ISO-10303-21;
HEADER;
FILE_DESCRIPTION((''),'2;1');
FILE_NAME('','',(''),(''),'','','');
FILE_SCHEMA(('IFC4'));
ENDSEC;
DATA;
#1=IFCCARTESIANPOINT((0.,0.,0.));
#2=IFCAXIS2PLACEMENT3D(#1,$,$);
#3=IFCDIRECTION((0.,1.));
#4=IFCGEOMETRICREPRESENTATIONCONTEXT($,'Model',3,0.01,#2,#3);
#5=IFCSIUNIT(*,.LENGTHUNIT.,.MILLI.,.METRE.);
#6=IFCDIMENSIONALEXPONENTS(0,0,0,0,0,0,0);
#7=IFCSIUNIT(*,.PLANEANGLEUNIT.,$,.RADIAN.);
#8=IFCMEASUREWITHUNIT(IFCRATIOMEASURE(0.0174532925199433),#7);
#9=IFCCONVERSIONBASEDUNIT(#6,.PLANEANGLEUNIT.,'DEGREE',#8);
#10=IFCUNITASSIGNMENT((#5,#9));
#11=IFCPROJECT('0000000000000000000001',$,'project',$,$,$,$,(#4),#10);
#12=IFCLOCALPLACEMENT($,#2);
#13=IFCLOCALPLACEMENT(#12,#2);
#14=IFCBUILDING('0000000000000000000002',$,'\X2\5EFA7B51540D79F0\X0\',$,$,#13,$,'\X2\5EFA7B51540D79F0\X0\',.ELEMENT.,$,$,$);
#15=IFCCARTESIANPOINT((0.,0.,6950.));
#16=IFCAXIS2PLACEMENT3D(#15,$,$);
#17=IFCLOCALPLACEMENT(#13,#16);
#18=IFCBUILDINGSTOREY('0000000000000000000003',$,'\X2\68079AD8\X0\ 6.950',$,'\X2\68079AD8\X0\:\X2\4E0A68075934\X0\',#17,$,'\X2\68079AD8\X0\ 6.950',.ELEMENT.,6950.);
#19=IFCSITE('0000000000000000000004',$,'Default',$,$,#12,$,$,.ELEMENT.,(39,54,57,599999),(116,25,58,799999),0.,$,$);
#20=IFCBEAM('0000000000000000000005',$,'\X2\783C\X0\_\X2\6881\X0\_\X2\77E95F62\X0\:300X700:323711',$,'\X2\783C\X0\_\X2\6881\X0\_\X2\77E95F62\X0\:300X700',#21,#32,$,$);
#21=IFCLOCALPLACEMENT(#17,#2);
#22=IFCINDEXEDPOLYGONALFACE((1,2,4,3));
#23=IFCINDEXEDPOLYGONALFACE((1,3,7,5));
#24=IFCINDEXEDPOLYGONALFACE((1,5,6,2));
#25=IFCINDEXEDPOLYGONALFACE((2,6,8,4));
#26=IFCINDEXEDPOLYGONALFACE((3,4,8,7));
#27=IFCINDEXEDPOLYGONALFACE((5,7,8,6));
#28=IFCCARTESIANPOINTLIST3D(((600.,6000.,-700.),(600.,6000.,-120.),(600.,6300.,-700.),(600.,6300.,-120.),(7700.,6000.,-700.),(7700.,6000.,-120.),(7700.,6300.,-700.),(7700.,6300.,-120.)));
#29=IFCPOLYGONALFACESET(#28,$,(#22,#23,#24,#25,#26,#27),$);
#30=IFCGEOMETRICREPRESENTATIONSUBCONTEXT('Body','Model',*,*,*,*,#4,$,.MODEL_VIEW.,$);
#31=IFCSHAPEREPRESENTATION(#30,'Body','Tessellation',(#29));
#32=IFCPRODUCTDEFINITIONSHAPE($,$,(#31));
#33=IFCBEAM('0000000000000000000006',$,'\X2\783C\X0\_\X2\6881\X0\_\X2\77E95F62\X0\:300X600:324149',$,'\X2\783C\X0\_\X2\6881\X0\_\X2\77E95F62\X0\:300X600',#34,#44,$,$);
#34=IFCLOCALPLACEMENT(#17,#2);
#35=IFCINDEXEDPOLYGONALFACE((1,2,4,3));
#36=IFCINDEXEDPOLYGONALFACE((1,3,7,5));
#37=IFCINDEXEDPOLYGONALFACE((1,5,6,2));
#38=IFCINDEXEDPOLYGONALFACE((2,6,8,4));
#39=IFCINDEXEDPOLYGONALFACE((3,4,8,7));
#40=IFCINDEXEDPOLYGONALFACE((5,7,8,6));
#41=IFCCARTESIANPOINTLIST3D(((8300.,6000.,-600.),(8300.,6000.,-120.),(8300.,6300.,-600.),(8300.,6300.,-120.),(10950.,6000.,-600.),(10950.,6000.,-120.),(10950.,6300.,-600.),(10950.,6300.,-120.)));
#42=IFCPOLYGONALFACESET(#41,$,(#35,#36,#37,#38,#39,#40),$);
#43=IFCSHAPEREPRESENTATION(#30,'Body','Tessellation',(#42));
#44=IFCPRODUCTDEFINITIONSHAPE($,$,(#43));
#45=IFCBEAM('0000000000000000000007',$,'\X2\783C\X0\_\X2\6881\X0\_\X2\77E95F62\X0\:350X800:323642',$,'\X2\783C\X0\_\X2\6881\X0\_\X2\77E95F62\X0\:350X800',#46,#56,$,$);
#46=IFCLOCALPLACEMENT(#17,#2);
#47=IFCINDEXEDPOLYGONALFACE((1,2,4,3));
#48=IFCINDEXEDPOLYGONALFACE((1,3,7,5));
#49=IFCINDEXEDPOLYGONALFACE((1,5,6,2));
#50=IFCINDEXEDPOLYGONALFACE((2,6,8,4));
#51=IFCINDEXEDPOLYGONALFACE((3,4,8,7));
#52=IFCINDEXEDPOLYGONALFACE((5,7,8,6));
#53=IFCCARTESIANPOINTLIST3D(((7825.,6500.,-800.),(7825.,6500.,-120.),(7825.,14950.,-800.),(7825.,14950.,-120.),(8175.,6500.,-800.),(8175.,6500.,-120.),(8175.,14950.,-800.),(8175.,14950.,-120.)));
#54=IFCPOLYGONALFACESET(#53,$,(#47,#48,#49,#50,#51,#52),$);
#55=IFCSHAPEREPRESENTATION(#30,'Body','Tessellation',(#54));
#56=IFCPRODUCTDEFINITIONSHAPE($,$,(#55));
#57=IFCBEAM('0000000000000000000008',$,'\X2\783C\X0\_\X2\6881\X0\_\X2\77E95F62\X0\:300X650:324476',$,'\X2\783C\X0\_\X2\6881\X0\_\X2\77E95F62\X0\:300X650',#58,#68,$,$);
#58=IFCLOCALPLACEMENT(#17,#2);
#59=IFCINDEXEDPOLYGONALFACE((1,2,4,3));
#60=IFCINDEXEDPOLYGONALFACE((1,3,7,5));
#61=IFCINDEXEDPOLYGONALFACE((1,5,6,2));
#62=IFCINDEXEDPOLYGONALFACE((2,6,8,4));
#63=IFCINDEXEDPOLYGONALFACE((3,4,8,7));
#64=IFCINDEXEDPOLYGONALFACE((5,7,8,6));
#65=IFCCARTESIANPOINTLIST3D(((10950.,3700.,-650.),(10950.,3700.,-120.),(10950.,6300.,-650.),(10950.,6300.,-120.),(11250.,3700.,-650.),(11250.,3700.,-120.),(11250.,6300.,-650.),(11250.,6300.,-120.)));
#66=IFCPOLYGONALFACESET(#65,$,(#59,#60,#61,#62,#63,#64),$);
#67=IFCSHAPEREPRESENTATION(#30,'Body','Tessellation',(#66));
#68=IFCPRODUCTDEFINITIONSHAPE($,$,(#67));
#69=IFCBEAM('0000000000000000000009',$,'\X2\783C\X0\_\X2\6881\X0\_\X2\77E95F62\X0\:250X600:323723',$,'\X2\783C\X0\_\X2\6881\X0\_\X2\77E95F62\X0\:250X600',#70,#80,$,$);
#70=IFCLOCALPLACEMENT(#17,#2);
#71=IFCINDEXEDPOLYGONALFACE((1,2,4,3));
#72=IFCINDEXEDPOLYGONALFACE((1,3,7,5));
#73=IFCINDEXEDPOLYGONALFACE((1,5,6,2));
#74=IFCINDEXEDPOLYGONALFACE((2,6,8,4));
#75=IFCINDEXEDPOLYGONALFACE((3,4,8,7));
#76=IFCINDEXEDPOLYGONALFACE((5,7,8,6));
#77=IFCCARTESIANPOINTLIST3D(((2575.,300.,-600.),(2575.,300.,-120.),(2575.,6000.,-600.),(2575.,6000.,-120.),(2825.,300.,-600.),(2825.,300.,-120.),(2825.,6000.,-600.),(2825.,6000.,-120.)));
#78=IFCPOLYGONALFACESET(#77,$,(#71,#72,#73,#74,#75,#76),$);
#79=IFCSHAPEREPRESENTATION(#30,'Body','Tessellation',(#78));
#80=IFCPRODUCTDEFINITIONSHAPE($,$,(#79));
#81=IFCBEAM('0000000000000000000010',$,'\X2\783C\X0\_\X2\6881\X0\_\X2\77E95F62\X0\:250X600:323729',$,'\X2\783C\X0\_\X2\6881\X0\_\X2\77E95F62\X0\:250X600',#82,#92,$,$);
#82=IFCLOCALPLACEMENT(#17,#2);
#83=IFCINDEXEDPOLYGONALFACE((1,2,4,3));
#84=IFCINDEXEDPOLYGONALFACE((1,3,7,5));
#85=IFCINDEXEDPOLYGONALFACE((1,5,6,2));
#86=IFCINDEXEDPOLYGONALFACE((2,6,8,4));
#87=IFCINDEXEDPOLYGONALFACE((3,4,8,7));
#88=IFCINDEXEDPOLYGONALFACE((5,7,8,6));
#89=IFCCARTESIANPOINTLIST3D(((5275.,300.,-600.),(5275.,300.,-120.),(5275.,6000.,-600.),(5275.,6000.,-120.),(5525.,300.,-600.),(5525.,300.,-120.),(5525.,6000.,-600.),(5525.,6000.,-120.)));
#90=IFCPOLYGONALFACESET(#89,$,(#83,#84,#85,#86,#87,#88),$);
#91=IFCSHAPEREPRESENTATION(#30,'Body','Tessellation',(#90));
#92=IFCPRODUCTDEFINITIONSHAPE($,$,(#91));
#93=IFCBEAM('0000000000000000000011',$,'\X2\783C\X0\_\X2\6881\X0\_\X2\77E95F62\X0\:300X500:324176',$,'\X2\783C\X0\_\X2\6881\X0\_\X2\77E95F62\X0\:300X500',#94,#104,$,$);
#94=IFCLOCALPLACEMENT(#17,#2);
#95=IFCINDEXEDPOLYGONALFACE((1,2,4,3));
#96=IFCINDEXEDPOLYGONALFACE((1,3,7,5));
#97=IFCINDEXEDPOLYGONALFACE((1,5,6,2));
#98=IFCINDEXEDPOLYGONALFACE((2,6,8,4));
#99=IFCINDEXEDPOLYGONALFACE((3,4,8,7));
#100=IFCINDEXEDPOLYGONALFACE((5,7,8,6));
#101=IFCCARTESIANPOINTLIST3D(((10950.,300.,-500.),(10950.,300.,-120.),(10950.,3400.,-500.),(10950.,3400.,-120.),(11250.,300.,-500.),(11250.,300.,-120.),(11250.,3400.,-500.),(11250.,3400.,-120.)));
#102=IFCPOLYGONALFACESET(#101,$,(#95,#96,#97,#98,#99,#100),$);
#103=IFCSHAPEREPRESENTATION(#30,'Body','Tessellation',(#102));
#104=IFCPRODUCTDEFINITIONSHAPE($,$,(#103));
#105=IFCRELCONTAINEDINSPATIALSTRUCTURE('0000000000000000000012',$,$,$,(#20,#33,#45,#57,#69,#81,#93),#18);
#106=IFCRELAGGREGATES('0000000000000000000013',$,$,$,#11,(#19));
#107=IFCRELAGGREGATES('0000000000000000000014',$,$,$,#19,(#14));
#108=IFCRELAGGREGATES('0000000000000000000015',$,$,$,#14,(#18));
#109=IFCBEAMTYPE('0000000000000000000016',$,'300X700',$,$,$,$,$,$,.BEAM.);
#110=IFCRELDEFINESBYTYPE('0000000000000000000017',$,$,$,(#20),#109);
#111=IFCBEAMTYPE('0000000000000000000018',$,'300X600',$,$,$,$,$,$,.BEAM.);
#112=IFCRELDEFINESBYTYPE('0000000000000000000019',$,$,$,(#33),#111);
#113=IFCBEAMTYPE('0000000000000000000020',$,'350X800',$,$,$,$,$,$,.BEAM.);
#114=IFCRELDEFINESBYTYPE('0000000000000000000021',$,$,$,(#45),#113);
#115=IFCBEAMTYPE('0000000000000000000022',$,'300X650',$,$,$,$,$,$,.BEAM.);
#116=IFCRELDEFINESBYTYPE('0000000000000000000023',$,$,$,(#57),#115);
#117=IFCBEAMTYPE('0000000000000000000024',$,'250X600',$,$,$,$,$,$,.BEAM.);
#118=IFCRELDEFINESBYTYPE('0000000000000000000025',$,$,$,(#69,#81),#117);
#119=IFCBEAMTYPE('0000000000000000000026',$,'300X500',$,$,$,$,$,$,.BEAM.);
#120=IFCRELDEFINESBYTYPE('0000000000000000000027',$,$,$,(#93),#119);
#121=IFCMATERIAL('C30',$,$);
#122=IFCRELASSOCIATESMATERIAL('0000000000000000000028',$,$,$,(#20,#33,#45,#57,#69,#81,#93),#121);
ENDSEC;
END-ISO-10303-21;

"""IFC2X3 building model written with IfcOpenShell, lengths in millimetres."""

from ifc_helpers import new_model, entity, si_unit, converted_unit, direction, frame, frame_2d, origin, origin_2d_with_axis, place, context, subcontext, project, spatial, rectangle, extrude, material, type_object, element, save


model = new_model("IFC2X3")

# Units and contexts
model_context = context("Model", 3, precision=0.01, world=origin(), true_north=direction((0.0, 1.0)))
body_context = subcontext(model_context, "Body", "Model", "MODEL_VIEW")
ifc_project = project(units=[si_unit("LENGTHUNIT", "METRE", prefix="MILLI"), converted_unit("PLANEANGLEUNIT", "DEGREE", entity("IfcRatioMeasure", 0.0174532925199433), si_unit("PLANEANGLEUNIT", "RADIAN"), dimensions=[0, 0, 0, 0, 0, 0, 0])], contexts=[model_context])

# Site, building, storey
site_placement = place(None, origin())
site = spatial("IfcSite", under=ifc_project, at=site_placement, Name="Default", CompositionType="ELEMENT", RefLatitude=(39, 54, 57, 599999), RefLongitude=(116, 25, 58, 799999), RefElevation=0.0)
building_placement = place(site_placement, origin())
building = spatial("IfcBuilding", under=site, at=building_placement, Name="建筑名称", LongName="建筑名称", CompositionType="ELEMENT")
storey_placement = place(building_placement, frame((0.0, 0.0, 6950.0)))
storey = spatial("IfcBuildingStorey", under=building, at=storey_placement, Name="标高 6.950", ObjectType="标高:上标头", LongName="标高 6.950", CompositionType="ELEMENT", Elevation=6950.0)

# Shared definitions
ifc_material = material(Name="C30")

# Beams
beam_type_1 = type_object("IfcBeamType", Name="300X700", PredefinedType="BEAM")
beam_1_placement = place(storey_placement, frame((150.0, 6150.0, 0.0)))
element("IfcBeam", 1, at=beam_1_placement, inside=storey, type_object=beam_type_1, material=ifc_material, Name="砼_梁_矩形:300X700:323711", ObjectType="砼_梁_矩形:300X700", context=body_context, shape_type="SweptSolid", body=[
    extrude(rectangle(XDim=580.0, YDim=300.0, at=origin_2d_with_axis()), frame((450.0, 0.0, -410.0), z_axis=(1.0, 0.0, 0.0), x_axis=(0.0, 0.0, -1.0)), (0.0, 0.0, 1.0), 7100.0),
])
beam_type_2 = type_object("IfcBeamType", Name="300X600", PredefinedType="BEAM")
beam_2_placement = place(storey_placement, frame((8000.0, 6150.0, 0.0)))
element("IfcBeam", 2, at=beam_2_placement, inside=storey, type_object=beam_type_2, material=ifc_material, Name="砼_梁_矩形:300X600:324149", ObjectType="砼_梁_矩形:300X600", context=body_context, shape_type="SweptSolid", body=[
    extrude(rectangle(XDim=480.0, YDim=300.0, at=frame_2d((0.0, 0.0), x_axis=(1.0, 0.0))), frame((300.0, 0.0, -360.0), z_axis=(1.0, 0.0, 0.0), x_axis=(0.0, 0.0, -1.0)), (0.0, 0.0, 1.0), 2650.0),
])
beam_type_3 = type_object("IfcBeamType", Name="350X800", PredefinedType="BEAM")
beam_3_placement = place(storey_placement, frame((8000.0, 6150.0, 0.0), z_axis=(0.0, 0.0, 1.0), x_axis=(0.0, 1.0, 0.0)))
element("IfcBeam", 3, at=beam_3_placement, inside=storey, type_object=beam_type_3, material=ifc_material, Name="砼_梁_矩形:350X800:323642", ObjectType="砼_梁_矩形:350X800", context=body_context, shape_type="SweptSolid", body=[
    extrude(rectangle(XDim=680.0, YDim=350.0, at=frame_2d((0.0, 0.0), x_axis=(1.0, 0.0))), frame((350.0, 0.0, -460.0), z_axis=(1.0, 0.0, 0.0), x_axis=(0.0, 0.0, -1.0)), (0.0, 0.0, 1.0), 8450.0),
])
beam_type_4 = type_object("IfcBeamType", Name="300X650", PredefinedType="BEAM")
beam_4_placement = place(storey_placement, frame((11100.0, 3700.0, 0.0), z_axis=(0.0, 0.0, 1.0), x_axis=(0.0, 1.0, 0.0)))
element("IfcBeam", 4, at=beam_4_placement, inside=storey, type_object=beam_type_4, material=ifc_material, Name="砼_梁_矩形:300X650:324476", ObjectType="砼_梁_矩形:300X650", context=body_context, shape_type="SweptSolid", body=[
    extrude(rectangle(XDim=530.0, YDim=300.0, at=frame_2d((0.0, 0.0), x_axis=(1.0, 0.0))), frame((0.0, 0.0, -385.0), z_axis=(1.0, 0.0, 0.0), x_axis=(0.0, 0.0, -1.0)), (0.0, 0.0, 1.0), 2600.0),
])
beam_type_5 = type_object("IfcBeamType", Name="250X600", PredefinedType="BEAM")
beam_5_placement = place(storey_placement, frame((2700.0, 0.0, 0.0), z_axis=(0.0, 0.0, 1.0), x_axis=(0.0, 1.0, 0.0)))
element("IfcBeam", 5, at=beam_5_placement, inside=storey, type_object=beam_type_5, material=ifc_material, Name="砼_梁_矩形:250X600:323723", ObjectType="砼_梁_矩形:250X600", context=body_context, shape_type="SweptSolid", body=[
    extrude(rectangle(XDim=480.0, YDim=250.0, at=frame_2d((0.0, 0.0), x_axis=(1.0, 0.0))), frame((300.0, 0.0, -360.0), z_axis=(1.0, 0.0, 0.0), x_axis=(0.0, 0.0, -1.0)), (0.0, 0.0, 1.0), 5700.0),
])
beam_6_placement = place(storey_placement, frame((5400.0, 0.0, 0.0), z_axis=(0.0, 0.0, 1.0), x_axis=(0.0, 1.0, 0.0)))
element("IfcBeam", 6, at=beam_6_placement, inside=storey, type_object=beam_type_5, material=ifc_material, Name="砼_梁_矩形:250X600:323729", ObjectType="砼_梁_矩形:250X600", context=body_context, shape_type="SweptSolid", body=[
    extrude(rectangle(XDim=480.0, YDim=250.0, at=frame_2d((0.0, 0.0), x_axis=(1.0, 0.0))), frame((300.0, 0.0, -360.0), z_axis=(1.0, 0.0, 0.0), x_axis=(0.0, 0.0, -1.0)), (0.0, 0.0, 1.0), 5700.0),
])
beam_type_6 = type_object("IfcBeamType", Name="300X500", PredefinedType="BEAM")
beam_7_placement = place(storey_placement, frame((11100.0, 0.0, 0.0), z_axis=(0.0, 0.0, 1.0), x_axis=(0.0, 1.0, 0.0)))
element("IfcBeam", 7, at=beam_7_placement, inside=storey, type_object=beam_type_6, material=ifc_material, Name="砼_梁_矩形:300X500:324176", ObjectType="砼_梁_矩形:300X500", context=body_context, shape_type="SweptSolid", body=[
    extrude(rectangle(XDim=380.0, YDim=300.0, at=frame_2d((0.0, 0.0), x_axis=(1.0, 0.0))), frame((300.0, 0.0, -310.0), z_axis=(1.0, 0.0, 0.0), x_axis=(0.0, 0.0, -1.0)), (0.0, 0.0, 1.0), 3100.0),
])

save(model, "model.ifc")
